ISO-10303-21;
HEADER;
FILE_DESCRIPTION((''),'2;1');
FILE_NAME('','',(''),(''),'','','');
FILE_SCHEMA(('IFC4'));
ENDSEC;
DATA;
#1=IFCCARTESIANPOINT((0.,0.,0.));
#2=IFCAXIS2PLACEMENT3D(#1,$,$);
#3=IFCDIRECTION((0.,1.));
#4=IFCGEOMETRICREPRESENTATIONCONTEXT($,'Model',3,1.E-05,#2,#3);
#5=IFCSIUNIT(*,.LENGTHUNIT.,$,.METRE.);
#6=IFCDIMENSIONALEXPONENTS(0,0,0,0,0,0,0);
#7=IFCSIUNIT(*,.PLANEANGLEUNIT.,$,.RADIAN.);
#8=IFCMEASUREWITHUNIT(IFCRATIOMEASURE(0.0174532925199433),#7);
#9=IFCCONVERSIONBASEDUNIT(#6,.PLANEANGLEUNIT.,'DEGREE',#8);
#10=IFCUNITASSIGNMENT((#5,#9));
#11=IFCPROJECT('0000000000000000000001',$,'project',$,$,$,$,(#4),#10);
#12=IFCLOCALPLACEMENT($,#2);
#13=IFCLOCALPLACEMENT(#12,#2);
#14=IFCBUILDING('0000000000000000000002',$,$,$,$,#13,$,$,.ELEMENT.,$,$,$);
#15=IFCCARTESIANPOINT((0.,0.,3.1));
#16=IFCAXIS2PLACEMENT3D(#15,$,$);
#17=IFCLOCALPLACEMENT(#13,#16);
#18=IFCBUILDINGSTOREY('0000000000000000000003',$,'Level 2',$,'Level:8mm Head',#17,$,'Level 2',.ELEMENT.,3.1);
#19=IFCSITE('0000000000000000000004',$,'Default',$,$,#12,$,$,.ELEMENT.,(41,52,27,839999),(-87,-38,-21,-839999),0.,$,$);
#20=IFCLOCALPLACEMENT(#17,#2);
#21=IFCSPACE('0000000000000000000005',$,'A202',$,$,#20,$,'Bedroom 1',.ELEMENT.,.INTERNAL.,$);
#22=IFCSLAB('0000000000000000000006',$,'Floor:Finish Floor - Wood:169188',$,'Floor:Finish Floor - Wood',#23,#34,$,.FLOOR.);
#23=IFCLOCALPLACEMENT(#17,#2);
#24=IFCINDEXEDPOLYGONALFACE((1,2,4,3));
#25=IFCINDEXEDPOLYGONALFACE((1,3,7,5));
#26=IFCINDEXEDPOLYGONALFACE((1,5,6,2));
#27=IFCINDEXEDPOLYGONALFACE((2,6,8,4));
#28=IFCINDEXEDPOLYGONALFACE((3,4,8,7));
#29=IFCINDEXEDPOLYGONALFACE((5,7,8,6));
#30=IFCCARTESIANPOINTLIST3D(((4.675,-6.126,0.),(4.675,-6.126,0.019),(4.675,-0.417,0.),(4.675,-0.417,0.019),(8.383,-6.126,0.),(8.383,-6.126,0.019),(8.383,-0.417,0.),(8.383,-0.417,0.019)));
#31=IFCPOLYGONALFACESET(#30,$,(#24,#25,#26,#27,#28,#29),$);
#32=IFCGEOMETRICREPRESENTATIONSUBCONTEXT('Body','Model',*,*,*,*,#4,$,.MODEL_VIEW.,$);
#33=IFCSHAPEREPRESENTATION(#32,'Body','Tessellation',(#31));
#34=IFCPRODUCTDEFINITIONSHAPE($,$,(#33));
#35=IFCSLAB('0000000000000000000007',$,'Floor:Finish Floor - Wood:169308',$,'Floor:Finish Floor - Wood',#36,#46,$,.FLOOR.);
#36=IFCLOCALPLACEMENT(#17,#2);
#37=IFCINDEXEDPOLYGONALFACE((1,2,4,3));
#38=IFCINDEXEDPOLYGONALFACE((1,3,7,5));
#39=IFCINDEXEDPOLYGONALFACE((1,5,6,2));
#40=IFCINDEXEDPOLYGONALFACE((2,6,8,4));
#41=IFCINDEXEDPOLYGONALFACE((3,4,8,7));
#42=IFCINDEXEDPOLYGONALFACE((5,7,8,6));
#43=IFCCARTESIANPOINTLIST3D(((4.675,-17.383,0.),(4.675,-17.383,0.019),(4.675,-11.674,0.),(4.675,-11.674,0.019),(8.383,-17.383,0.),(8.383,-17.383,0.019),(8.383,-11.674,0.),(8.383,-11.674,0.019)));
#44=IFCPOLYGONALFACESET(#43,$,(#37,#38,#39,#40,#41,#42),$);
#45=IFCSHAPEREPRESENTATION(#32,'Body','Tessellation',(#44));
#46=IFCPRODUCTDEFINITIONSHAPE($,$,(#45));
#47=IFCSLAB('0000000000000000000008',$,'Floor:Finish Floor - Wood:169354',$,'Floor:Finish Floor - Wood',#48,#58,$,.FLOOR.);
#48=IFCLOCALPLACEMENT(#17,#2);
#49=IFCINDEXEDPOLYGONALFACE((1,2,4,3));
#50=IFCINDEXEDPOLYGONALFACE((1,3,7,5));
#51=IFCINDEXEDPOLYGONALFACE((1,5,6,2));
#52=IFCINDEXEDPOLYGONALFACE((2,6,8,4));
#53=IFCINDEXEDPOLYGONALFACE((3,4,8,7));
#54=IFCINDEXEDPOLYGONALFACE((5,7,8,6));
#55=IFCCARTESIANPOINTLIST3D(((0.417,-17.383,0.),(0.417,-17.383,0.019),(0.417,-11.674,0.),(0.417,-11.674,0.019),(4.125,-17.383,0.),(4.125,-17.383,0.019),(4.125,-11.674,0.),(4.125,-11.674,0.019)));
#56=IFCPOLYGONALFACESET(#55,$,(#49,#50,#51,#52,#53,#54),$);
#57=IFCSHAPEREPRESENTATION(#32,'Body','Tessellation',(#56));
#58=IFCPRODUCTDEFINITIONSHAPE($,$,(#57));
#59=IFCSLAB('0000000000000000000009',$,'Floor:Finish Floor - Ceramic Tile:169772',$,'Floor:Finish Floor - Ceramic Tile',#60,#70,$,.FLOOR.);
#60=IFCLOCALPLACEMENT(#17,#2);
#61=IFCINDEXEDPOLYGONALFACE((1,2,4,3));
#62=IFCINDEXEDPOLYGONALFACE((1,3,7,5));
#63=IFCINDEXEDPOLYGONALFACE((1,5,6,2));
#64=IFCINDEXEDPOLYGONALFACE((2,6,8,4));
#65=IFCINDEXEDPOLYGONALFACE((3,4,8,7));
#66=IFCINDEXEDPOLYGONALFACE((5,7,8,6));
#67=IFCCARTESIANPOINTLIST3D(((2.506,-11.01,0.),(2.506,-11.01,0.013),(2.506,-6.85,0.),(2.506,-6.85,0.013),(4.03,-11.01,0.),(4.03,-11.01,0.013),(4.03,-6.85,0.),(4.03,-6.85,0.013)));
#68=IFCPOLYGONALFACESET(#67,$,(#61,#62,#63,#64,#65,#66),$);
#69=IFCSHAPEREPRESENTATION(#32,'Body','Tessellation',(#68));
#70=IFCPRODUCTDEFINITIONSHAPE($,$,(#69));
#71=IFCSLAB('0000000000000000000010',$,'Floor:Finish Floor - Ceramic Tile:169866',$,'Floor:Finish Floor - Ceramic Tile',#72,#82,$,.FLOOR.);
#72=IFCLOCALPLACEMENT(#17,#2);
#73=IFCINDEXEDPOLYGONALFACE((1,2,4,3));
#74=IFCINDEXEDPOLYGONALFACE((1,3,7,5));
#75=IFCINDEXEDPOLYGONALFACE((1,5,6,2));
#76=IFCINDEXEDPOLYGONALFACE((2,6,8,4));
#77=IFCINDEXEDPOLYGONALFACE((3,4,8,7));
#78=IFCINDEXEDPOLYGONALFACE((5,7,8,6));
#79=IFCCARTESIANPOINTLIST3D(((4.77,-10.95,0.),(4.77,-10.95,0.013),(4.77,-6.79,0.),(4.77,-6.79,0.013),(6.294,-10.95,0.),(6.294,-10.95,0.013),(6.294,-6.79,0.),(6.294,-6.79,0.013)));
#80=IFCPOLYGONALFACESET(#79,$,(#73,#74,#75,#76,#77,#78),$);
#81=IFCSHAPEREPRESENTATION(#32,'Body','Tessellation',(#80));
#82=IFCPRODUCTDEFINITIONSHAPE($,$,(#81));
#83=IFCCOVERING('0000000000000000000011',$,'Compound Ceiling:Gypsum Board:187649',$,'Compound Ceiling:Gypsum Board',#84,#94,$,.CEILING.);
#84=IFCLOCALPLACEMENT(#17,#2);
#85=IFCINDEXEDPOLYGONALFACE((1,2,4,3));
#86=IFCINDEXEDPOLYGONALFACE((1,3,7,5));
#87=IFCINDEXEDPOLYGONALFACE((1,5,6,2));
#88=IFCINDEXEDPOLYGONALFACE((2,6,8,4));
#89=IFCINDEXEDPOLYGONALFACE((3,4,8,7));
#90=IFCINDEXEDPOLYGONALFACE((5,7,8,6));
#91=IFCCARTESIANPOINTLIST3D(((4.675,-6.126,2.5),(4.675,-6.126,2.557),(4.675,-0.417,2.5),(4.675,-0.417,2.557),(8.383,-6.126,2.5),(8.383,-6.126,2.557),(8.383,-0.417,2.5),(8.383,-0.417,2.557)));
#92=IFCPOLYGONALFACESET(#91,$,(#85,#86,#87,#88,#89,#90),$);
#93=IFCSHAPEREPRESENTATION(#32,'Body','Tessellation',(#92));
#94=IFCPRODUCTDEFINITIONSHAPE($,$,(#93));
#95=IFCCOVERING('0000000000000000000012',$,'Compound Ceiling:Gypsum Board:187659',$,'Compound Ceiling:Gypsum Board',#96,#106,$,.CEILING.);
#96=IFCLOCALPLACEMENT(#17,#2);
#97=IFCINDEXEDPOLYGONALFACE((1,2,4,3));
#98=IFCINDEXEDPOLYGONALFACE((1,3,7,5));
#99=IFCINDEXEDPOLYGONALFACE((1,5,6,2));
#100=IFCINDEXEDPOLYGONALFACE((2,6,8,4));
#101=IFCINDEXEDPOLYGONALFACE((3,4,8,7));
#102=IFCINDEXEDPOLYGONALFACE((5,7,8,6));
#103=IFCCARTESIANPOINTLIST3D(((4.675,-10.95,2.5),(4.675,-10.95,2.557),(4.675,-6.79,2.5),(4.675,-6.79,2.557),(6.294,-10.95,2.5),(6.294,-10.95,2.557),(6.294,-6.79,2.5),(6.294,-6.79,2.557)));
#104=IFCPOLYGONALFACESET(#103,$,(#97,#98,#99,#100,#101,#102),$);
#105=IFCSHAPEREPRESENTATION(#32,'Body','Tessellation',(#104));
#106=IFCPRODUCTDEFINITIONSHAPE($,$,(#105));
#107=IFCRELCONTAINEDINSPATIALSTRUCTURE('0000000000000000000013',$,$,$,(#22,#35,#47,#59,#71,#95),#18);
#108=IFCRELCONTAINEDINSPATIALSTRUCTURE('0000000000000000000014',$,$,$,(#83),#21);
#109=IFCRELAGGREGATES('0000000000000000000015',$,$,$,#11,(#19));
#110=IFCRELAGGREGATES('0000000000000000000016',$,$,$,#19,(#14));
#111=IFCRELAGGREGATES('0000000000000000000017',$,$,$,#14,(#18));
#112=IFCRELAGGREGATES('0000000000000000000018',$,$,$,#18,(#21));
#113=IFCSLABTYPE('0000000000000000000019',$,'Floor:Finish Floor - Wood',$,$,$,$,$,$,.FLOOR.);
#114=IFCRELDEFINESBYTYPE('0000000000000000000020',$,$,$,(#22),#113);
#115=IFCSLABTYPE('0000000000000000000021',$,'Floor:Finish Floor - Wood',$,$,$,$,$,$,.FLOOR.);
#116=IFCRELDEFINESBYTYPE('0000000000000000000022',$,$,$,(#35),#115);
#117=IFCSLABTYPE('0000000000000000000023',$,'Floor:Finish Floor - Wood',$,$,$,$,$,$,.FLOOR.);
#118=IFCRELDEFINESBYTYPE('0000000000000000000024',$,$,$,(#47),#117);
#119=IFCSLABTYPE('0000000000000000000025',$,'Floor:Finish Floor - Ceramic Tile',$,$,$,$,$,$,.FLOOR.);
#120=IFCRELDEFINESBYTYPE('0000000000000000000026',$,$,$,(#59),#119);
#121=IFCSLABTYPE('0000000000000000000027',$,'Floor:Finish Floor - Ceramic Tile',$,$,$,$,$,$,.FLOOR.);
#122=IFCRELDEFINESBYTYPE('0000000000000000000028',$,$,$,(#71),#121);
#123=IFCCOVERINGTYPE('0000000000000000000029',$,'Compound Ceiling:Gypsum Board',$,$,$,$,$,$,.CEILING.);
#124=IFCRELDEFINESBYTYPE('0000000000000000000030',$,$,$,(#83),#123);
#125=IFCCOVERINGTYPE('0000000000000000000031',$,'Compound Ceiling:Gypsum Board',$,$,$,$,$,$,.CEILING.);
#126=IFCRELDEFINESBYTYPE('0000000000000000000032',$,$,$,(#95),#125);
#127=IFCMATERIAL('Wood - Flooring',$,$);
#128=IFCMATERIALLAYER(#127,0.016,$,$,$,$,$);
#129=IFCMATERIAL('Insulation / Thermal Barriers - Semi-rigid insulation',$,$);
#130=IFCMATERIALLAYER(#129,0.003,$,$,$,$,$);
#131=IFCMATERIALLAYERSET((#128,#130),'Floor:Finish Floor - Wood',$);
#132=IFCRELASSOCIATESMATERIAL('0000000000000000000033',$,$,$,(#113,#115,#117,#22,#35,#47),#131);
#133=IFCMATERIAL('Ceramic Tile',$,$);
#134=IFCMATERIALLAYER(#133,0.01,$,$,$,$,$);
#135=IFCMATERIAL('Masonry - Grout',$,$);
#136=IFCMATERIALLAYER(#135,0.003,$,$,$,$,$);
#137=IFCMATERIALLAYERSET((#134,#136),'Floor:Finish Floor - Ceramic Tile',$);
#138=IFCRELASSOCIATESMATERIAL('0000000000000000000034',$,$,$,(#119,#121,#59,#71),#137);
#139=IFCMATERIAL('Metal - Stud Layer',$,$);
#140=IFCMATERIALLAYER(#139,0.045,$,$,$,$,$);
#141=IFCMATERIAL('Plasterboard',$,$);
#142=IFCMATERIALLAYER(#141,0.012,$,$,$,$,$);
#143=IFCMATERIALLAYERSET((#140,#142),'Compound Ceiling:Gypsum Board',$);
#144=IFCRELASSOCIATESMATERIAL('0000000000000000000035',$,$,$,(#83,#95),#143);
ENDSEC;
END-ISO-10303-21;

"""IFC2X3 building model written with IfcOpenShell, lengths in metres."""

from ifc_helpers import new_model, entity, si_unit, converted_unit, direction, frame, frame_2d, origin, origin_2d_with_axis, place, context, subcontext, project, spatial, rectangle, extrude, material, layer, layer_set, layer_usage, type_object, element, save


model = new_model("IFC2X3")

# Units and contexts
model_context = context("Model", 3, precision=1e-05, world=origin(), true_north=direction((0.0, 1.0)))
body_context = subcontext(model_context, "Body", "Model", "MODEL_VIEW")
ifc_project = project(units=[si_unit("LENGTHUNIT", "METRE"), converted_unit("PLANEANGLEUNIT", "DEGREE", entity("IfcRatioMeasure", 0.0174532925199433), si_unit("PLANEANGLEUNIT", "RADIAN"), dimensions=[0, 0, 0, 0, 0, 0, 0])], contexts=[model_context])

# Site, building, storey
site_placement = place(None, origin())
site = spatial("IfcSite", under=ifc_project, at=site_placement, Name="Default", CompositionType="ELEMENT", RefLatitude=(41, 52, 27, 839999), RefLongitude=(-87, -38, -21, -839999), RefElevation=0.0)
building_placement = place(site_placement, origin())
building = spatial("IfcBuilding", under=site, at=building_placement, CompositionType="ELEMENT")
storey_placement = place(building_placement, frame((0.0, 0.0, 3.1)))
storey = spatial("IfcBuildingStorey", under=building, at=storey_placement, Name="Level 2", ObjectType="Level:8mm Head", LongName="Level 2", CompositionType="ELEMENT", Elevation=3.1)

# Slabs
ifc_material_1 = material(Name="Wood - Flooring")
ifc_layer_1 = layer(ifc_material_1, 0.016)
ifc_material_2 = material(Name="Insulation / Thermal Barriers - Semi-rigid insulation")
ifc_layer_2 = layer(ifc_material_2, 0.003)
ifc_layer_set_1 = layer_set([ifc_layer_1, ifc_layer_2], Name="Floor:Finish Floor - Wood")
ifc_layer_usage_1 = layer_usage(ifc_layer_set_1, "AXIS3", "POSITIVE", 0.0)
slab_type_1 = type_object("IfcSlabType", Name="Floor:Finish Floor - Wood", PredefinedType="FLOOR", material=ifc_layer_set_1)
slab_1_placement = place(storey_placement, origin())
element("IfcSlab", 1, at=slab_1_placement, inside=storey, type_object=slab_type_1, material=ifc_layer_usage_1, Name="Floor:Finish Floor - Wood:169188", ObjectType="Floor:Finish Floor - Wood", PredefinedType="FLOOR", context=body_context, shape_type="SweptSolid", body=[
    extrude(rectangle(XDim=5.709, YDim=3.708, at=frame_2d((0.0, 0.0), x_axis=(1.0, 0.0))), frame((6.529, -3.2715, 0.019), z_axis=(0.0, 0.0, -1.0), x_axis=(0.0, 1.0, 0.0)), (0.0, 0.0, 1.0), 0.019),
])
ifc_layer_usage_2 = layer_usage(ifc_layer_set_1, "AXIS3", "POSITIVE", 0.0)
slab_type_2 = type_object("IfcSlabType", Name="Floor:Finish Floor - Wood", PredefinedType="FLOOR", material=ifc_layer_set_1)
slab_2_placement = place(storey_placement, origin())
element("IfcSlab", 2, at=slab_2_placement, inside=storey, type_object=slab_type_2, material=ifc_layer_usage_2, Name="Floor:Finish Floor - Wood:169308", ObjectType="Floor:Finish Floor - Wood", PredefinedType="FLOOR", context=body_context, shape_type="SweptSolid", body=[
    extrude(rectangle(XDim=5.709, YDim=3.708, at=frame_2d((0.0, 0.0), x_axis=(1.0, 0.0))), frame((6.529, -14.5285, 0.019), z_axis=(0.0, 0.0, -1.0), x_axis=(0.0, 1.0, 0.0)), (0.0, 0.0, 1.0), 0.019),
])
ifc_layer_usage_3 = layer_usage(ifc_layer_set_1, "AXIS3", "POSITIVE", 0.0)
slab_type_3 = type_object("IfcSlabType", Name="Floor:Finish Floor - Wood", PredefinedType="FLOOR", material=ifc_layer_set_1)
slab_3_placement = place(storey_placement, origin())
element("IfcSlab", 3, at=slab_3_placement, inside=storey, type_object=slab_type_3, material=ifc_layer_usage_3, Name="Floor:Finish Floor - Wood:169354", ObjectType="Floor:Finish Floor - Wood", PredefinedType="FLOOR", context=body_context, shape_type="SweptSolid", body=[
    extrude(rectangle(XDim=5.709, YDim=3.708, at=frame_2d((0.0, 0.0), x_axis=(1.0, 0.0))), frame((2.271, -14.5285, 0.019), z_axis=(0.0, 0.0, -1.0), x_axis=(0.0, 1.0, 0.0)), (0.0, 0.0, 1.0), 0.019),
])
ifc_material_3 = material(Name="Ceramic Tile")
ifc_layer_3 = layer(ifc_material_3, 0.01)
ifc_material_4 = material(Name="Masonry - Grout")
ifc_layer_4 = layer(ifc_material_4, 0.003)
ifc_layer_set_2 = layer_set([ifc_layer_3, ifc_layer_4], Name="Floor:Finish Floor - Ceramic Tile")
ifc_layer_usage_4 = layer_usage(ifc_layer_set_2, "AXIS3", "POSITIVE", 0.0)
slab_type_4 = type_object("IfcSlabType", Name="Floor:Finish Floor - Ceramic Tile", PredefinedType="FLOOR", material=ifc_layer_set_2)
slab_4_placement = place(storey_placement, origin())
element("IfcSlab", 4, at=slab_4_placement, inside=storey, type_object=slab_type_4, material=ifc_layer_usage_4, Name="Floor:Finish Floor - Ceramic Tile:169772", ObjectType="Floor:Finish Floor - Ceramic Tile", PredefinedType="FLOOR", context=body_context, shape_type="SweptSolid", body=[
    extrude(rectangle(XDim=4.16, YDim=1.524, at=frame_2d((0.0, 0.0), x_axis=(1.0, 0.0))), frame((3.268, -8.93, 0.013), z_axis=(0.0, 0.0, -1.0), x_axis=(0.0, 1.0, 0.0)), (0.0, 0.0, 1.0), 0.013),
])
ifc_layer_usage_5 = layer_usage(ifc_layer_set_2, "AXIS3", "POSITIVE", 0.0)
slab_type_5 = type_object("IfcSlabType", Name="Floor:Finish Floor - Ceramic Tile", PredefinedType="FLOOR", material=ifc_layer_set_2)
slab_5_placement = place(storey_placement, origin())
element("IfcSlab", 5, at=slab_5_placement, inside=storey, type_object=slab_type_5, material=ifc_layer_usage_5, Name="Floor:Finish Floor - Ceramic Tile:169866", ObjectType="Floor:Finish Floor - Ceramic Tile", PredefinedType="FLOOR", context=body_context, shape_type="SweptSolid", body=[
    extrude(rectangle(XDim=4.16, YDim=1.524, at=frame_2d((0.0, 0.0), x_axis=(1.0, 0.0))), frame((5.532, -8.87, 0.013), z_axis=(0.0, 0.0, -1.0), x_axis=(0.0, 1.0, 0.0)), (0.0, 0.0, 1.0), 0.013),
])

# Shared definitions
ifc_material_5 = material(Name="Metal - Stud Layer")
ifc_material_6 = material(Name="Plasterboard")

# Shared definitions
ifc_layer_5 = layer(ifc_material_5, 0.045)
ifc_layer_6 = layer(ifc_material_6, 0.012)
ifc_layer_set_3 = layer_set([ifc_layer_5, ifc_layer_6], Name="Compound Ceiling:Gypsum Board")

# Shared definitions
space_1_placement = place(storey_placement, origin())
space_1 = spatial("IfcSpace", under=storey, at=space_1_placement, Name="A202", LongName="Bedroom 1", CompositionType="ELEMENT", InteriorOrExteriorSpace="INTERNAL")

# Coverings
ifc_layer_usage_6 = layer_usage(ifc_layer_set_3, "AXIS3", "POSITIVE", 0.0)
covering_type_1 = type_object("IfcCoveringType", Name="Compound Ceiling:Gypsum Board", PredefinedType="CEILING")
covering_1_placement = place(space_1_placement, origin())
element("IfcCovering", 6, at=covering_1_placement, inside=space_1, type_object=covering_type_1, material=ifc_layer_usage_6, Name="Compound Ceiling:Gypsum Board:187649", ObjectType="Compound Ceiling:Gypsum Board", PredefinedType="CEILING", context=body_context, shape_type="SweptSolid", body=[
    extrude(rectangle(XDim=5.709, YDim=3.708, at=origin_2d_with_axis()), frame((6.529, -3.2715, 2.5), z_axis=(0.0, 0.0, 1.0), x_axis=(0.0, 1.0, 0.0)), (0.0, 0.0, 1.0), 0.057),
])
ifc_layer_usage_7 = layer_usage(ifc_layer_set_3, "AXIS3", "POSITIVE", 0.0)
covering_type_2 = type_object("IfcCoveringType", Name="Compound Ceiling:Gypsum Board", PredefinedType="CEILING")
covering_2_placement = place(storey_placement, origin())
element("IfcCovering", 7, at=covering_2_placement, inside=storey, type_object=covering_type_2, material=ifc_layer_usage_7, Name="Compound Ceiling:Gypsum Board:187659", ObjectType="Compound Ceiling:Gypsum Board", PredefinedType="CEILING", context=body_context, shape_type="SweptSolid", body=[
    extrude(rectangle(XDim=1.619, YDim=4.16, at=frame_2d((0.0, 0.0), x_axis=(1.0, 0.0))), frame((5.4845, -8.87, 2.5)), (0.0, 0.0, 1.0), 0.057),
])

save(model, "model.ifc")
